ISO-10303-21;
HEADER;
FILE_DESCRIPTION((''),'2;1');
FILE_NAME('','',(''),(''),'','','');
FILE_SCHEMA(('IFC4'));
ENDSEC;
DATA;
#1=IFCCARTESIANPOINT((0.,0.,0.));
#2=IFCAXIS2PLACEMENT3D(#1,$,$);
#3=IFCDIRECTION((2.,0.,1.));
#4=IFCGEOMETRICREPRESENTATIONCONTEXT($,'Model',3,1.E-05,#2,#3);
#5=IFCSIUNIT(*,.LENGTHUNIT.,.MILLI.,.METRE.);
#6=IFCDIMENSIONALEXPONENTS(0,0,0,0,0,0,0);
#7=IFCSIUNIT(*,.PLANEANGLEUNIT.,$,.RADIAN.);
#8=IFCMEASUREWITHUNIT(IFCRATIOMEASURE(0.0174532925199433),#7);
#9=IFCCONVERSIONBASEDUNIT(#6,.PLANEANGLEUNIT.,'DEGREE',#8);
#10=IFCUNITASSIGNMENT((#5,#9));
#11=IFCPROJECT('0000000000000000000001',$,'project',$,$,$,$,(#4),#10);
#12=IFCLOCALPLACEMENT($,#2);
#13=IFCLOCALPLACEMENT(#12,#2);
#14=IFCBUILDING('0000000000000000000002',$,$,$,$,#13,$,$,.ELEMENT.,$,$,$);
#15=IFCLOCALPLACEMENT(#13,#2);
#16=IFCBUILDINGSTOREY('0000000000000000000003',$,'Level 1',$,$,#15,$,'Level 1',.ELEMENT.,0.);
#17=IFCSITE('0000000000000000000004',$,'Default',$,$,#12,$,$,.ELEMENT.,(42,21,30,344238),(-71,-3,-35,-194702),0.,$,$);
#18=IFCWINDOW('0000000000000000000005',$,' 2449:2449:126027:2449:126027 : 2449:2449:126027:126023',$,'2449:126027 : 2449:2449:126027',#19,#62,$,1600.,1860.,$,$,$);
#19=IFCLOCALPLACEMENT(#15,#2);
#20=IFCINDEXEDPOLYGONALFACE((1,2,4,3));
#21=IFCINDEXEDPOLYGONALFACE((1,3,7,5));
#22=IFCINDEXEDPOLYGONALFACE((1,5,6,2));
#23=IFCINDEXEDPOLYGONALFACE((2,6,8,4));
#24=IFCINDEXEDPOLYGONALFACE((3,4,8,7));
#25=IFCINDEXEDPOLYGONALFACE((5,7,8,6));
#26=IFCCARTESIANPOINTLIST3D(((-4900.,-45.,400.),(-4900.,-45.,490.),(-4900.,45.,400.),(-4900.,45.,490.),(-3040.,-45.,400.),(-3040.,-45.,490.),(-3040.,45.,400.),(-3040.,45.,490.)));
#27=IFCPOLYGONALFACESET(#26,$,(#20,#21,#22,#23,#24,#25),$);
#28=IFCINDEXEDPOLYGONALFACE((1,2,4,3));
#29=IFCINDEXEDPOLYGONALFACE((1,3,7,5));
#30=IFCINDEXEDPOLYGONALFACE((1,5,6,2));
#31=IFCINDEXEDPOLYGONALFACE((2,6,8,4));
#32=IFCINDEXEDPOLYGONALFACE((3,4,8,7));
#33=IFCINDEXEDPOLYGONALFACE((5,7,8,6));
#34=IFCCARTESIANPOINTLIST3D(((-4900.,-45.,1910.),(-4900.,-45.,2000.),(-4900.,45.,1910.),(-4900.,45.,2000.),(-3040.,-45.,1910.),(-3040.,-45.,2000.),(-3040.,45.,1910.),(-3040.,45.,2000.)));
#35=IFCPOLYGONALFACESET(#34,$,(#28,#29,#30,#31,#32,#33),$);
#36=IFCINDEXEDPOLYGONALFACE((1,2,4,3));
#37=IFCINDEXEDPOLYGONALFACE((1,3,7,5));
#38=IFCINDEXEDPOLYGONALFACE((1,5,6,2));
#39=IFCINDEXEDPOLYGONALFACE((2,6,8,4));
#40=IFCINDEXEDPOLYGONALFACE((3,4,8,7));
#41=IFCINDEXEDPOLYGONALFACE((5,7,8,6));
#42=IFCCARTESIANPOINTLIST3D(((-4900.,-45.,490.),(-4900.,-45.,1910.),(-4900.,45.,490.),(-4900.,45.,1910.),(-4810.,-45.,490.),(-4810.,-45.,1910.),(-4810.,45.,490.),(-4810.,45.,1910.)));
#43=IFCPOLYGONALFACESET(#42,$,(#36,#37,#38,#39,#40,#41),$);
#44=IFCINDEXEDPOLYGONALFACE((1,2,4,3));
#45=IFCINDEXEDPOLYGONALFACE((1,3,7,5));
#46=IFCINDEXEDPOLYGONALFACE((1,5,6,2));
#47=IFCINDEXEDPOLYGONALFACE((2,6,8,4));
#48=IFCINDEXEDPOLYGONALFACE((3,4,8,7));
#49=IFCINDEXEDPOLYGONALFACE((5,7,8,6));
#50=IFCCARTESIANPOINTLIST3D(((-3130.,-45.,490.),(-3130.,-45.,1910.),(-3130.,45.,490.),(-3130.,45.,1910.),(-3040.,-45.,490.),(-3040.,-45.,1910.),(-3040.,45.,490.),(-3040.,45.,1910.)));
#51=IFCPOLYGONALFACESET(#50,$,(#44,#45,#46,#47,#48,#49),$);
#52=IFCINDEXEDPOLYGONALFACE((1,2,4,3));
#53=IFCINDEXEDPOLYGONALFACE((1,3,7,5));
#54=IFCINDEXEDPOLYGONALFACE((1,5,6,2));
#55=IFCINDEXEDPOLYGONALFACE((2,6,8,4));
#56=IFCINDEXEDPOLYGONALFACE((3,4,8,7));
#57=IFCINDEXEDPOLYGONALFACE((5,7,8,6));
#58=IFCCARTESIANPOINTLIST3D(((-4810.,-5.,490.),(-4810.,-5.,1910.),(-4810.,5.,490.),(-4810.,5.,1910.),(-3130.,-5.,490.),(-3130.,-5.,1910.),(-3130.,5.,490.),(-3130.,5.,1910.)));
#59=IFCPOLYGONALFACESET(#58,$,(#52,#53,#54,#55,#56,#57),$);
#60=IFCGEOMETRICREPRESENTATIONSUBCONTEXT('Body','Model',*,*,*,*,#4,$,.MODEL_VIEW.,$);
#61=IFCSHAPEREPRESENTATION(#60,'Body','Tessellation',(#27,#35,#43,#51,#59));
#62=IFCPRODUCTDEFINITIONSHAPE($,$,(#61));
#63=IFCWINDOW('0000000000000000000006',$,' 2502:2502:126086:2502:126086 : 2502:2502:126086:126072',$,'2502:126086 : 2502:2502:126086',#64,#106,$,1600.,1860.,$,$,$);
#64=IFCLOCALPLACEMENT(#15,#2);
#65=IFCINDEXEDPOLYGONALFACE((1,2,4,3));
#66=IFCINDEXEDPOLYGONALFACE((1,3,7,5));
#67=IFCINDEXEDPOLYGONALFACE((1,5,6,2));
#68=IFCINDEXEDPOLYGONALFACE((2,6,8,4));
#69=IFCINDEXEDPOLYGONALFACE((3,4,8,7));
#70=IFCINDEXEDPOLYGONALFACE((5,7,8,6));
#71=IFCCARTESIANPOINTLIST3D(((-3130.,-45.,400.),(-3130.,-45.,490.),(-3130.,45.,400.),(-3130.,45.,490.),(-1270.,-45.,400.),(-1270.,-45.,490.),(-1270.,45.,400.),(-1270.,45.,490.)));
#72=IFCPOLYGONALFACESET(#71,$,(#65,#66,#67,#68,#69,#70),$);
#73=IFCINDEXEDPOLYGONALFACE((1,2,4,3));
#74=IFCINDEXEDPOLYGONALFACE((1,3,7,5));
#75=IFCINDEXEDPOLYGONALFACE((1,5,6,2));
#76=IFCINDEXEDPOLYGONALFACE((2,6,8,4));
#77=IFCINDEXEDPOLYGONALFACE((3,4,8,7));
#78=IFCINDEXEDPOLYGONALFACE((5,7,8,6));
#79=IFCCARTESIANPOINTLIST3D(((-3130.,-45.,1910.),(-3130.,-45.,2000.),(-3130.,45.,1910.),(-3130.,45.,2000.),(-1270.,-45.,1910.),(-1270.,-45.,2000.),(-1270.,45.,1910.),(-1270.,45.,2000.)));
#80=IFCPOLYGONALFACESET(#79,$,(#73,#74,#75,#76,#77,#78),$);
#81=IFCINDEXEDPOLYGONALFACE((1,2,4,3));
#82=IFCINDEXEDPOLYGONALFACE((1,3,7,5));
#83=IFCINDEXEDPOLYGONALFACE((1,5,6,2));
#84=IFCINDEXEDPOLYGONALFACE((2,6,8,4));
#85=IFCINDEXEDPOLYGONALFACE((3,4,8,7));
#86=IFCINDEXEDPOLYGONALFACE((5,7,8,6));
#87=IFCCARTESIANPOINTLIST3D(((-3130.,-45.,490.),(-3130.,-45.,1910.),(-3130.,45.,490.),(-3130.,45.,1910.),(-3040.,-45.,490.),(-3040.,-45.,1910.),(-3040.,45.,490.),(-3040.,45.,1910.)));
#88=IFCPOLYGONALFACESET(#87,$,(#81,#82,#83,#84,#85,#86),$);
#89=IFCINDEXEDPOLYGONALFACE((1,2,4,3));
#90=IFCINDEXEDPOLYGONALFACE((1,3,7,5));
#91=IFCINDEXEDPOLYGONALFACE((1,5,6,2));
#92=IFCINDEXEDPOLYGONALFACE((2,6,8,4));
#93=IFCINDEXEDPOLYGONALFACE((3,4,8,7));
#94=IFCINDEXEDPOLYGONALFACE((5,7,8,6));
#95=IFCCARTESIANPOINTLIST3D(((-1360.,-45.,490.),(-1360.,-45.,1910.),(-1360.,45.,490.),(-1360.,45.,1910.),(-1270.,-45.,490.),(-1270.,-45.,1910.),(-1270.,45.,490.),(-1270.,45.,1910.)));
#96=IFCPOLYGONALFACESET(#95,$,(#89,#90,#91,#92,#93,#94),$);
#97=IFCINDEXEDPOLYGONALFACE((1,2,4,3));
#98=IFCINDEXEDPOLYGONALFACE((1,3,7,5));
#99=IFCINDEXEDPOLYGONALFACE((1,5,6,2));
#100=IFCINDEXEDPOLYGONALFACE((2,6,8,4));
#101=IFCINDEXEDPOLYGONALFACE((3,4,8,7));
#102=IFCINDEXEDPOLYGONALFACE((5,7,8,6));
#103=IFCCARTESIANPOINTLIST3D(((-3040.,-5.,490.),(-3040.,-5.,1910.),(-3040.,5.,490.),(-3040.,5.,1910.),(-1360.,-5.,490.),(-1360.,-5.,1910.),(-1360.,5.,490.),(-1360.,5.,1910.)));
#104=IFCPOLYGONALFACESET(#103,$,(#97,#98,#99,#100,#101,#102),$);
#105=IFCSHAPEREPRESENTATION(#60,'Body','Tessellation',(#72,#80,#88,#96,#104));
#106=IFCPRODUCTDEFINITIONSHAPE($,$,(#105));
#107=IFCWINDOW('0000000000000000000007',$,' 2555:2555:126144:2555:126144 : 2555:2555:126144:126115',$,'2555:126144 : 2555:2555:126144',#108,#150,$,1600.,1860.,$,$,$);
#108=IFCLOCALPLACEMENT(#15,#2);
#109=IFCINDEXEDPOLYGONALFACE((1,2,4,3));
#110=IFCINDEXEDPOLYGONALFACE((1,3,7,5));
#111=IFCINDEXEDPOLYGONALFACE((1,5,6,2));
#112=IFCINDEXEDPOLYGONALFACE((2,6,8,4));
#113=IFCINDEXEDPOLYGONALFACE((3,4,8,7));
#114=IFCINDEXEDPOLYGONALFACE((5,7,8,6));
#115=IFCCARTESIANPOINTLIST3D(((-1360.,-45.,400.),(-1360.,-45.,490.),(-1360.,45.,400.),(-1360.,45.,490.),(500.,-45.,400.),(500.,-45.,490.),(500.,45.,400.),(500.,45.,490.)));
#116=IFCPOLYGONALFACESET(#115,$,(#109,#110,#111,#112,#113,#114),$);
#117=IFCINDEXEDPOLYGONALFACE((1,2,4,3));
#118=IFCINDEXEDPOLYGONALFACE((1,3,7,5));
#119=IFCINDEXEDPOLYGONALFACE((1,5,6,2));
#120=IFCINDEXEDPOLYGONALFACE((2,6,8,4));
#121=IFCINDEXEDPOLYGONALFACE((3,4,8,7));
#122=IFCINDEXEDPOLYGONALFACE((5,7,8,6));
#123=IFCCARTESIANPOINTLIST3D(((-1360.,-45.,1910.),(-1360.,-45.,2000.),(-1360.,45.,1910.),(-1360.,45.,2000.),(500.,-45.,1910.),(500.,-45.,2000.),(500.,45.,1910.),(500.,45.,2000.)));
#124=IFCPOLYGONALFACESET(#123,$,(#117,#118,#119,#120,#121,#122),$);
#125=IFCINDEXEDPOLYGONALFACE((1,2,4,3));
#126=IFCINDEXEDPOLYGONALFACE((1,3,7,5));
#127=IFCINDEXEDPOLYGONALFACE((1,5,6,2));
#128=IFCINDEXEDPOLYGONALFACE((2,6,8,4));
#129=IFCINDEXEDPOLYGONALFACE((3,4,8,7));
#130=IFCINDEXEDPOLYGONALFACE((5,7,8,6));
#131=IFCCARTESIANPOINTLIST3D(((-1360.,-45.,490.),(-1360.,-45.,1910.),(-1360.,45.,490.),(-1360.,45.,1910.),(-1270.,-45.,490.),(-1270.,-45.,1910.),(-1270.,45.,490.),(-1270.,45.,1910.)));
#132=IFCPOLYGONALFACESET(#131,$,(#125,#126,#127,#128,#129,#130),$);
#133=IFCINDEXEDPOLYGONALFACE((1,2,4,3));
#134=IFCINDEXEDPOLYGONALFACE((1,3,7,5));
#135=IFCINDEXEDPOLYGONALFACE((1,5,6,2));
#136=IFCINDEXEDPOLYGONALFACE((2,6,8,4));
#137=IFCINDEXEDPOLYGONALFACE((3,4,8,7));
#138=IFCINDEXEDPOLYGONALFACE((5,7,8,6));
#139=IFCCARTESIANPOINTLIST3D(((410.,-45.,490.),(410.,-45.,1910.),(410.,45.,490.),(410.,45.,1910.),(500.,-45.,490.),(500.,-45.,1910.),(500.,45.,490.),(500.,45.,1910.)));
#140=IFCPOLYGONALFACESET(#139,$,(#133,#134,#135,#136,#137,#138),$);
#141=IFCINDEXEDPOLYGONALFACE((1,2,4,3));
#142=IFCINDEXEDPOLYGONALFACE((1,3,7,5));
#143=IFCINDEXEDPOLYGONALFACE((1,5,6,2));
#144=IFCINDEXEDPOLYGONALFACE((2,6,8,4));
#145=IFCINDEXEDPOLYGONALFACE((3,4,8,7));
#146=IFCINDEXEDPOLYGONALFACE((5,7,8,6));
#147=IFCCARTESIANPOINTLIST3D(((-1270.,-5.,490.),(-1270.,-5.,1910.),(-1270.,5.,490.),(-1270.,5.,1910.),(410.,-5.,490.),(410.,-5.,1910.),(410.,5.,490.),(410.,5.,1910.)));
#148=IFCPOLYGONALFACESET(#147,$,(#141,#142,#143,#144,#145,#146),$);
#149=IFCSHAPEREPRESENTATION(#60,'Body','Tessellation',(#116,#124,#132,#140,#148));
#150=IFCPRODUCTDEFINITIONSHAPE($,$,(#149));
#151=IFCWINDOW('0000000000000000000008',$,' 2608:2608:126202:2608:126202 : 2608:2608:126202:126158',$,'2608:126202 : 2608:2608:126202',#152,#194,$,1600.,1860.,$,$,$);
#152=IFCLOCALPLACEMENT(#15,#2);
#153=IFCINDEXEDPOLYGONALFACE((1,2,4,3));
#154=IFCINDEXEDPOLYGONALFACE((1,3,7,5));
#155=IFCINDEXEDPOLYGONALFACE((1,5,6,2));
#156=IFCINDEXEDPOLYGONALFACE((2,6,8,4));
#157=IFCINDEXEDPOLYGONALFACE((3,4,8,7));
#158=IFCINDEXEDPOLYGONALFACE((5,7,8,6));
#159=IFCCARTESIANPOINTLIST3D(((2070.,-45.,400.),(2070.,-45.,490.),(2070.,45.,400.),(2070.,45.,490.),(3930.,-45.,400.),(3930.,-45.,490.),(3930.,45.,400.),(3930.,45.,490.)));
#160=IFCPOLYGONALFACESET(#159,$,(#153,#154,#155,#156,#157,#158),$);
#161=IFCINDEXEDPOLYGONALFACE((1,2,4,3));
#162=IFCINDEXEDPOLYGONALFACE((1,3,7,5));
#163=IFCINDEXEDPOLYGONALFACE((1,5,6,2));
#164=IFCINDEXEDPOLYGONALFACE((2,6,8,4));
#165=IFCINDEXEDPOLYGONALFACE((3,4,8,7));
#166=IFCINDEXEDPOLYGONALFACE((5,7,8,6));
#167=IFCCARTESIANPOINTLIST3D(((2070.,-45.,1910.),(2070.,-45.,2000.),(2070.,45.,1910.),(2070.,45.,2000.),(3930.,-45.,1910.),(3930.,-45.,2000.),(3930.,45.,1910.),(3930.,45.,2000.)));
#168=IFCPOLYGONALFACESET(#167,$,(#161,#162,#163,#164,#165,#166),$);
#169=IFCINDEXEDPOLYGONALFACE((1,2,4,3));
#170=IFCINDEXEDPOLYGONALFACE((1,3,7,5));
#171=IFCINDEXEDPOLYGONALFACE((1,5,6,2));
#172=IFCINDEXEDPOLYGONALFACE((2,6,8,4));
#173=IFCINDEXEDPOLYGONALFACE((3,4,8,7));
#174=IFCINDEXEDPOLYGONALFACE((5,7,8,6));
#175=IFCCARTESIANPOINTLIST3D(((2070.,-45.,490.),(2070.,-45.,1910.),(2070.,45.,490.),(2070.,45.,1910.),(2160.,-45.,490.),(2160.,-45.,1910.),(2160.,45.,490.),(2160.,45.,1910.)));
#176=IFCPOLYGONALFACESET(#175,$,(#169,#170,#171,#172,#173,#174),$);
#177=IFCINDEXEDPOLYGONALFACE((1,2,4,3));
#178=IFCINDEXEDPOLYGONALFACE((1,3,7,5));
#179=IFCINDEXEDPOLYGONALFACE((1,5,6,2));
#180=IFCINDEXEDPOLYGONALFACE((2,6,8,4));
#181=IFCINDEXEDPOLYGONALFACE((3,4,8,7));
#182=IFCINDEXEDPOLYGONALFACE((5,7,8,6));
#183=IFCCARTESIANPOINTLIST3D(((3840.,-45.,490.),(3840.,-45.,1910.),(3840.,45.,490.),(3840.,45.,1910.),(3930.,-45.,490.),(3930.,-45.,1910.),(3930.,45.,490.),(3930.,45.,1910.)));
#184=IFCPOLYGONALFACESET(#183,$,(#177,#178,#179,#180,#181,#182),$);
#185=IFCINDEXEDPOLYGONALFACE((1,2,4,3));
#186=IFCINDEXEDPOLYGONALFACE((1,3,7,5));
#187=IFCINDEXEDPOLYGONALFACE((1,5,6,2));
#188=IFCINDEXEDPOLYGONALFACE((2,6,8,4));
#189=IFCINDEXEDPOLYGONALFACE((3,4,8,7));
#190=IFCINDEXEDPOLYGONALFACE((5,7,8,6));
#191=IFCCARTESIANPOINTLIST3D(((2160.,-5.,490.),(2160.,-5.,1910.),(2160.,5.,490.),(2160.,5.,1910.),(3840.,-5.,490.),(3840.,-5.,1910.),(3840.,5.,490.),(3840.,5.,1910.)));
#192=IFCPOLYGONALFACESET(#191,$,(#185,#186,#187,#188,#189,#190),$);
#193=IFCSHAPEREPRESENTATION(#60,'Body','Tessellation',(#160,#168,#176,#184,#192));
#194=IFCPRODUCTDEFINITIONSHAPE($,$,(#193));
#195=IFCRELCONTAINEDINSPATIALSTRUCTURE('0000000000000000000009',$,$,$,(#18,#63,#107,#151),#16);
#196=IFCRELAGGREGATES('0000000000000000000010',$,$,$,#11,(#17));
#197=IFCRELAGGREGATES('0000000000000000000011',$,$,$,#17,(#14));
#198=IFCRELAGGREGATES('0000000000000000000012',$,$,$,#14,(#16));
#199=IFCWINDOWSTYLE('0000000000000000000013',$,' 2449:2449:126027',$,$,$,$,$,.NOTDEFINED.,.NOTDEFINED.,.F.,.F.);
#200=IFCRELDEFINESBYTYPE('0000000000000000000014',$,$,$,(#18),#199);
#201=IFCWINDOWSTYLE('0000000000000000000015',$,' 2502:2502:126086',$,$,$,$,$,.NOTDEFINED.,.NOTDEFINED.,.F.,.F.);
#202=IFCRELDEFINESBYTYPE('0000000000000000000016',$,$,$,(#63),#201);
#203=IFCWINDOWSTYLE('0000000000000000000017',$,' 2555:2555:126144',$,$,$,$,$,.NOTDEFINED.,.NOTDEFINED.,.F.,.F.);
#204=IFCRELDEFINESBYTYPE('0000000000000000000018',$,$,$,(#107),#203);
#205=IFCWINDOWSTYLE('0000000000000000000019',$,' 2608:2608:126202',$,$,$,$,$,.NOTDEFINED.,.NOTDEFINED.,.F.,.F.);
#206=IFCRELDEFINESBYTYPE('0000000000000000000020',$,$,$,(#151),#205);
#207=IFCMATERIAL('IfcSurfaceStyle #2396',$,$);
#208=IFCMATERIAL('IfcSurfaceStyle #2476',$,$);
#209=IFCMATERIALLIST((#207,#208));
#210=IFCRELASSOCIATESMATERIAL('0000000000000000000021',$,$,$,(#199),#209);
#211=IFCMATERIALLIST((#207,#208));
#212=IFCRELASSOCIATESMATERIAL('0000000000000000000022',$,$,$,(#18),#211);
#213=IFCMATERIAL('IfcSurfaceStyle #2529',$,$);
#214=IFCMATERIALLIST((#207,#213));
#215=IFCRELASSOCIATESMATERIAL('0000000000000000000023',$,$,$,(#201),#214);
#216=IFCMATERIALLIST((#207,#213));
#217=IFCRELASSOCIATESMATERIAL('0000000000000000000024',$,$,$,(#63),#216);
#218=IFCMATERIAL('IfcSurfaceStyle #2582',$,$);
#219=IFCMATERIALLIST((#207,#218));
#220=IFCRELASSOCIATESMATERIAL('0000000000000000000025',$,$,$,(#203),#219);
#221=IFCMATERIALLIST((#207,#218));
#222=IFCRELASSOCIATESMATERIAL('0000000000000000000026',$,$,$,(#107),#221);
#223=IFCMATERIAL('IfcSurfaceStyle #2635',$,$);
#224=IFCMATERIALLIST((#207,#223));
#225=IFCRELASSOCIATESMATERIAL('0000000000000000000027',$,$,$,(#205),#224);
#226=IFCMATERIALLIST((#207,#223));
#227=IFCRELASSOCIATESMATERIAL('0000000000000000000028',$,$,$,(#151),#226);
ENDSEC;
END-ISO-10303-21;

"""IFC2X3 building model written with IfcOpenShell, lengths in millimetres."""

from ifc_helpers import new_model, entity, si_unit, converted_unit, direction, frame, frame_2d, origin, origin_2d_with_axis, place, context, subcontext, project, spatial, rectangle, extrude, source, transform, mapped, material, material_list, type_object, type_shapes, element, save


model = new_model("IFC2X3")

# Units and contexts
model_context = context("Model", 3, precision=1e-05, world=origin(), true_north=direction((2.0, 0.0, 1.0)))
body_context = subcontext(model_context, "Body", "Model", "MODEL_VIEW")
ifc_project = project(units=[si_unit("LENGTHUNIT", "METRE", prefix="MILLI"), converted_unit("PLANEANGLEUNIT", "DEGREE", entity("IfcRatioMeasure", 0.0174532925199433), si_unit("PLANEANGLEUNIT", "RADIAN"), dimensions=[0, 0, 0, 0, 0, 0, 0])], contexts=[model_context])

# Site, building, storey
site_placement = place(None, origin())
site = spatial("IfcSite", under=ifc_project, at=site_placement, Name="Default", CompositionType="ELEMENT", RefLatitude=(42, 21, 30, 344238), RefLongitude=(-71, -3, -35, -194702), RefElevation=0.0)
building_placement = place(site_placement, origin())
building = spatial("IfcBuilding", under=site, at=building_placement, CompositionType="ELEMENT")
storey_placement = place(building_placement, origin())
storey = spatial("IfcBuildingStorey", under=building, at=storey_placement, Name="Level 1", LongName="Level 1", CompositionType="ELEMENT", Elevation=0.0)

# Windows
ifc_material_1 = material(Name="IfcSurfaceStyle #2396")
ifc_material_2 = material(Name="IfcSurfaceStyle #2476")
ifc_material_list_1 = material_list([ifc_material_1, ifc_material_2])
ifc_material_list_2 = material_list([ifc_material_1, ifc_material_2])
window_style_1 = type_object("IfcWindowStyle", Name=" 2449:2449:126027", ConstructionType="NOTDEFINED", OperationType="NOTDEFINED", ParameterTakesPrecedence=False, Sizeable=False, material=ifc_material_list_2)
shared_shape_1 = source(origin(), body_context, "Body", "SweptSolid", [
    extrude(rectangle(XDim=1860.0, YDim=90.0, at=frame_2d((0.0, 0.0), x_axis=(1.0, 0.0))), frame((-3970.0, 0.0, 400.0), z_axis=(0.0, 0.0, 1.0), x_axis=(-1.0, 0.0, 0.0)), (0.0, 0.0, 1.0), 90.0),
    extrude(rectangle(XDim=1860.0, YDim=90.0, at=frame_2d((0.0, 0.0), x_axis=(1.0, 0.0))), frame((-3970.0, 0.0, 1910.0), z_axis=(0.0, 0.0, 1.0), x_axis=(-1.0, 0.0, 0.0)), (0.0, 0.0, 1.0), 90.0),
    extrude(rectangle(XDim=90.0, YDim=90.0, at=origin_2d_with_axis()), frame((-4855.0, 0.0, 490.0), z_axis=(0.0, 0.0, 1.0), x_axis=(-1.0, 0.0, 0.0)), (0.0, 0.0, 1.0), 1420.0),
    extrude(rectangle(XDim=90.0, YDim=90.0, at=frame_2d((0.0, 0.0), x_axis=(1.0, 0.0))), frame((-3085.0, 0.0, 490.0), z_axis=(0.0, 0.0, 1.0), x_axis=(-1.0, 0.0, 0.0)), (0.0, 0.0, 1.0), 1420.0),
    extrude(rectangle(XDim=1680.0, YDim=10.0, at=frame_2d((0.0, 0.0), x_axis=(1.0, 0.0))), frame((-3970.0, 0.0, 490.0), z_axis=(0.0, 0.0, 1.0), x_axis=(-1.0, 0.0, 0.0)), (0.0, 0.0, 1.0), 1420.0),
])
type_shapes(window_style_1, [shared_shape_1])
window_1_placement = place(storey_placement, origin())
element("IfcWindow", 1, at=window_1_placement, inside=storey, type_object=window_style_1, material=ifc_material_list_1, Name=" 2449:2449:126027:2449:126027 : 2449:2449:126027:126023", ObjectType="2449:126027 : 2449:2449:126027", OverallHeight=1600.0, OverallWidth=1860.0, context=body_context, shape_type="MappedRepresentation", body=[
    mapped(shared_shape_1, transform((0.0, 0.0, 0.0), scale=1.0)),
])
ifc_material_3 = material(Name="IfcSurfaceStyle #2529")
ifc_material_list_3 = material_list([ifc_material_1, ifc_material_3])
ifc_material_list_4 = material_list([ifc_material_1, ifc_material_3])
window_style_2 = type_object("IfcWindowStyle", Name=" 2502:2502:126086", ConstructionType="NOTDEFINED", OperationType="NOTDEFINED", ParameterTakesPrecedence=False, Sizeable=False, material=ifc_material_list_4)
shared_shape_2 = source(origin(), body_context, "Body", "SweptSolid", [
    extrude(rectangle(XDim=1860.0, YDim=90.0, at=frame_2d((0.0, 0.0), x_axis=(1.0, 0.0))), frame((-2200.0, 0.0, 400.0), z_axis=(0.0, 0.0, 1.0), x_axis=(-1.0, 0.0, 0.0)), (0.0, 0.0, 1.0), 90.0),
    extrude(rectangle(XDim=1860.0, YDim=90.0, at=frame_2d((0.0, 0.0), x_axis=(1.0, 0.0))), frame((-2200.0, 0.0, 1910.0), z_axis=(0.0, 0.0, 1.0), x_axis=(-1.0, 0.0, 0.0)), (0.0, 0.0, 1.0), 90.0),
    extrude(rectangle(XDim=90.0, YDim=90.0, at=frame_2d((0.0, 0.0), x_axis=(1.0, 0.0))), frame((-3085.0, 0.0, 490.0), z_axis=(0.0, 0.0, 1.0), x_axis=(-1.0, 0.0, 0.0)), (0.0, 0.0, 1.0), 1420.0),
    extrude(rectangle(XDim=90.0, YDim=90.0, at=frame_2d((0.0, 0.0), x_axis=(1.0, 0.0))), frame((-1315.0, 0.0, 490.0), z_axis=(0.0, 0.0, 1.0), x_axis=(-1.0, 0.0, 0.0)), (0.0, 0.0, 1.0), 1420.0),
    extrude(rectangle(XDim=1680.0, YDim=10.0, at=origin_2d_with_axis()), frame((-2200.0, 0.0, 490.0), z_axis=(0.0, 0.0, 1.0), x_axis=(-1.0, 0.0, 0.0)), (0.0, 0.0, 1.0), 1420.0),
])
type_shapes(window_style_2, [shared_shape_2])
window_2_placement = place(storey_placement, origin())
element("IfcWindow", 2, at=window_2_placement, inside=storey, type_object=window_style_2, material=ifc_material_list_3, Name=" 2502:2502:126086:2502:126086 : 2502:2502:126086:126072", ObjectType="2502:126086 : 2502:2502:126086", OverallHeight=1600.0, OverallWidth=1860.0, context=body_context, shape_type="MappedRepresentation", body=[
    mapped(shared_shape_2, transform((0.0, 0.0, 0.0), scale=1.0)),
])
ifc_material_4 = material(Name="IfcSurfaceStyle #2582")
ifc_material_list_5 = material_list([ifc_material_1, ifc_material_4])
ifc_material_list_6 = material_list([ifc_material_1, ifc_material_4])
window_style_3 = type_object("IfcWindowStyle", Name=" 2555:2555:126144", ConstructionType="NOTDEFINED", OperationType="NOTDEFINED", ParameterTakesPrecedence=False, Sizeable=False, material=ifc_material_list_6)
shared_shape_3 = source(origin(), body_context, "Body", "SweptSolid", [
    extrude(rectangle(XDim=1860.0, YDim=90.0, at=origin_2d_with_axis()), frame((-430.0, 0.0, 400.0), z_axis=(0.0, 0.0, 1.0), x_axis=(-1.0, 0.0, 0.0)), (0.0, 0.0, 1.0), 90.0),
    extrude(rectangle(XDim=1860.0, YDim=90.0, at=origin_2d_with_axis()), frame((-430.0, 0.0, 1910.0), z_axis=(0.0, 0.0, 1.0), x_axis=(-1.0, 0.0, 0.0)), (0.0, 0.0, 1.0), 90.0),
    extrude(rectangle(XDim=90.0, YDim=90.0, at=frame_2d((0.0, 0.0), x_axis=(1.0, 0.0))), frame((-1315.0, 0.0, 490.0), z_axis=(0.0, 0.0, 1.0), x_axis=(-1.0, 0.0, 0.0)), (0.0, 0.0, 1.0), 1420.0),
    extrude(rectangle(XDim=90.0, YDim=90.0, at=origin_2d_with_axis()), frame((455.0, 0.0, 490.0), z_axis=(0.0, 0.0, 1.0), x_axis=(-1.0, 0.0, 0.0)), (0.0, 0.0, 1.0), 1420.0),
    extrude(rectangle(XDim=1680.0, YDim=10.0, at=frame_2d((0.0, 0.0), x_axis=(1.0, 0.0))), frame((-430.0, 0.0, 490.0), z_axis=(0.0, 0.0, 1.0), x_axis=(-1.0, 0.0, 0.0)), (0.0, 0.0, 1.0), 1420.0),
])
type_shapes(window_style_3, [shared_shape_3])
window_3_placement = place(storey_placement, origin())
element("IfcWindow", 3, at=window_3_placement, inside=storey, type_object=window_style_3, material=ifc_material_list_5, Name=" 2555:2555:126144:2555:126144 : 2555:2555:126144:126115", ObjectType="2555:126144 : 2555:2555:126144", OverallHeight=1600.0, OverallWidth=1860.0, context=body_context, shape_type="MappedRepresentation", body=[
    mapped(shared_shape_3, transform((0.0, 0.0, 0.0), scale=1.0)),
])
ifc_material_5 = material(Name="IfcSurfaceStyle #2635")
ifc_material_list_7 = material_list([ifc_material_1, ifc_material_5])
ifc_material_list_8 = material_list([ifc_material_1, ifc_material_5])
window_style_4 = type_object("IfcWindowStyle", Name=" 2608:2608:126202", ConstructionType="NOTDEFINED", OperationType="NOTDEFINED", ParameterTakesPrecedence=False, Sizeable=False, material=ifc_material_list_8)
shared_shape_4 = source(origin(), body_context, "Body", "SweptSolid", [
    extrude(rectangle(XDim=1860.0, YDim=90.0, at=frame_2d((0.0, 0.0), x_axis=(1.0, 0.0))), frame((3000.0, 0.0, 400.0), z_axis=(0.0, 0.0, 1.0), x_axis=(-1.0, 0.0, 0.0)), (0.0, 0.0, 1.0), 90.0),
    extrude(rectangle(XDim=1860.0, YDim=90.0, at=frame_2d((0.0, 0.0), x_axis=(1.0, 0.0))), frame((3000.0, 0.0, 1910.0), z_axis=(0.0, 0.0, 1.0), x_axis=(-1.0, 0.0, 0.0)), (0.0, 0.0, 1.0), 90.0),
    extrude(rectangle(XDim=90.0, YDim=90.0, at=origin_2d_with_axis()), frame((2115.0, 0.0, 490.0), z_axis=(0.0, 0.0, 1.0), x_axis=(-1.0, 0.0, 0.0)), (0.0, 0.0, 1.0), 1420.0),
    extrude(rectangle(XDim=90.0, YDim=90.0, at=frame_2d((0.0, 0.0), x_axis=(1.0, 0.0))), frame((3885.0, 0.0, 490.0), z_axis=(0.0, 0.0, 1.0), x_axis=(-1.0, 0.0, 0.0)), (0.0, 0.0, 1.0), 1420.0),
    extrude(rectangle(XDim=1680.0, YDim=10.0, at=frame_2d((0.0, 0.0), x_axis=(1.0, 0.0))), frame((3000.0, 0.0, 490.0), z_axis=(0.0, 0.0, 1.0), x_axis=(-1.0, 0.0, 0.0)), (0.0, 0.0, 1.0), 1420.0),
])
type_shapes(window_style_4, [shared_shape_4])
window_4_placement = place(storey_placement, origin())
element("IfcWindow", 4, at=window_4_placement, inside=storey, type_object=window_style_4, material=ifc_material_list_7, Name=" 2608:2608:126202:2608:126202 : 2608:2608:126202:126158", ObjectType="2608:126202 : 2608:2608:126202", OverallHeight=1600.0, OverallWidth=1860.0, context=body_context, shape_type="MappedRepresentation", body=[
    mapped(shared_shape_4, transform((0.0, 0.0, 0.0), scale=1.0)),
])

save(model, "model.ifc")
